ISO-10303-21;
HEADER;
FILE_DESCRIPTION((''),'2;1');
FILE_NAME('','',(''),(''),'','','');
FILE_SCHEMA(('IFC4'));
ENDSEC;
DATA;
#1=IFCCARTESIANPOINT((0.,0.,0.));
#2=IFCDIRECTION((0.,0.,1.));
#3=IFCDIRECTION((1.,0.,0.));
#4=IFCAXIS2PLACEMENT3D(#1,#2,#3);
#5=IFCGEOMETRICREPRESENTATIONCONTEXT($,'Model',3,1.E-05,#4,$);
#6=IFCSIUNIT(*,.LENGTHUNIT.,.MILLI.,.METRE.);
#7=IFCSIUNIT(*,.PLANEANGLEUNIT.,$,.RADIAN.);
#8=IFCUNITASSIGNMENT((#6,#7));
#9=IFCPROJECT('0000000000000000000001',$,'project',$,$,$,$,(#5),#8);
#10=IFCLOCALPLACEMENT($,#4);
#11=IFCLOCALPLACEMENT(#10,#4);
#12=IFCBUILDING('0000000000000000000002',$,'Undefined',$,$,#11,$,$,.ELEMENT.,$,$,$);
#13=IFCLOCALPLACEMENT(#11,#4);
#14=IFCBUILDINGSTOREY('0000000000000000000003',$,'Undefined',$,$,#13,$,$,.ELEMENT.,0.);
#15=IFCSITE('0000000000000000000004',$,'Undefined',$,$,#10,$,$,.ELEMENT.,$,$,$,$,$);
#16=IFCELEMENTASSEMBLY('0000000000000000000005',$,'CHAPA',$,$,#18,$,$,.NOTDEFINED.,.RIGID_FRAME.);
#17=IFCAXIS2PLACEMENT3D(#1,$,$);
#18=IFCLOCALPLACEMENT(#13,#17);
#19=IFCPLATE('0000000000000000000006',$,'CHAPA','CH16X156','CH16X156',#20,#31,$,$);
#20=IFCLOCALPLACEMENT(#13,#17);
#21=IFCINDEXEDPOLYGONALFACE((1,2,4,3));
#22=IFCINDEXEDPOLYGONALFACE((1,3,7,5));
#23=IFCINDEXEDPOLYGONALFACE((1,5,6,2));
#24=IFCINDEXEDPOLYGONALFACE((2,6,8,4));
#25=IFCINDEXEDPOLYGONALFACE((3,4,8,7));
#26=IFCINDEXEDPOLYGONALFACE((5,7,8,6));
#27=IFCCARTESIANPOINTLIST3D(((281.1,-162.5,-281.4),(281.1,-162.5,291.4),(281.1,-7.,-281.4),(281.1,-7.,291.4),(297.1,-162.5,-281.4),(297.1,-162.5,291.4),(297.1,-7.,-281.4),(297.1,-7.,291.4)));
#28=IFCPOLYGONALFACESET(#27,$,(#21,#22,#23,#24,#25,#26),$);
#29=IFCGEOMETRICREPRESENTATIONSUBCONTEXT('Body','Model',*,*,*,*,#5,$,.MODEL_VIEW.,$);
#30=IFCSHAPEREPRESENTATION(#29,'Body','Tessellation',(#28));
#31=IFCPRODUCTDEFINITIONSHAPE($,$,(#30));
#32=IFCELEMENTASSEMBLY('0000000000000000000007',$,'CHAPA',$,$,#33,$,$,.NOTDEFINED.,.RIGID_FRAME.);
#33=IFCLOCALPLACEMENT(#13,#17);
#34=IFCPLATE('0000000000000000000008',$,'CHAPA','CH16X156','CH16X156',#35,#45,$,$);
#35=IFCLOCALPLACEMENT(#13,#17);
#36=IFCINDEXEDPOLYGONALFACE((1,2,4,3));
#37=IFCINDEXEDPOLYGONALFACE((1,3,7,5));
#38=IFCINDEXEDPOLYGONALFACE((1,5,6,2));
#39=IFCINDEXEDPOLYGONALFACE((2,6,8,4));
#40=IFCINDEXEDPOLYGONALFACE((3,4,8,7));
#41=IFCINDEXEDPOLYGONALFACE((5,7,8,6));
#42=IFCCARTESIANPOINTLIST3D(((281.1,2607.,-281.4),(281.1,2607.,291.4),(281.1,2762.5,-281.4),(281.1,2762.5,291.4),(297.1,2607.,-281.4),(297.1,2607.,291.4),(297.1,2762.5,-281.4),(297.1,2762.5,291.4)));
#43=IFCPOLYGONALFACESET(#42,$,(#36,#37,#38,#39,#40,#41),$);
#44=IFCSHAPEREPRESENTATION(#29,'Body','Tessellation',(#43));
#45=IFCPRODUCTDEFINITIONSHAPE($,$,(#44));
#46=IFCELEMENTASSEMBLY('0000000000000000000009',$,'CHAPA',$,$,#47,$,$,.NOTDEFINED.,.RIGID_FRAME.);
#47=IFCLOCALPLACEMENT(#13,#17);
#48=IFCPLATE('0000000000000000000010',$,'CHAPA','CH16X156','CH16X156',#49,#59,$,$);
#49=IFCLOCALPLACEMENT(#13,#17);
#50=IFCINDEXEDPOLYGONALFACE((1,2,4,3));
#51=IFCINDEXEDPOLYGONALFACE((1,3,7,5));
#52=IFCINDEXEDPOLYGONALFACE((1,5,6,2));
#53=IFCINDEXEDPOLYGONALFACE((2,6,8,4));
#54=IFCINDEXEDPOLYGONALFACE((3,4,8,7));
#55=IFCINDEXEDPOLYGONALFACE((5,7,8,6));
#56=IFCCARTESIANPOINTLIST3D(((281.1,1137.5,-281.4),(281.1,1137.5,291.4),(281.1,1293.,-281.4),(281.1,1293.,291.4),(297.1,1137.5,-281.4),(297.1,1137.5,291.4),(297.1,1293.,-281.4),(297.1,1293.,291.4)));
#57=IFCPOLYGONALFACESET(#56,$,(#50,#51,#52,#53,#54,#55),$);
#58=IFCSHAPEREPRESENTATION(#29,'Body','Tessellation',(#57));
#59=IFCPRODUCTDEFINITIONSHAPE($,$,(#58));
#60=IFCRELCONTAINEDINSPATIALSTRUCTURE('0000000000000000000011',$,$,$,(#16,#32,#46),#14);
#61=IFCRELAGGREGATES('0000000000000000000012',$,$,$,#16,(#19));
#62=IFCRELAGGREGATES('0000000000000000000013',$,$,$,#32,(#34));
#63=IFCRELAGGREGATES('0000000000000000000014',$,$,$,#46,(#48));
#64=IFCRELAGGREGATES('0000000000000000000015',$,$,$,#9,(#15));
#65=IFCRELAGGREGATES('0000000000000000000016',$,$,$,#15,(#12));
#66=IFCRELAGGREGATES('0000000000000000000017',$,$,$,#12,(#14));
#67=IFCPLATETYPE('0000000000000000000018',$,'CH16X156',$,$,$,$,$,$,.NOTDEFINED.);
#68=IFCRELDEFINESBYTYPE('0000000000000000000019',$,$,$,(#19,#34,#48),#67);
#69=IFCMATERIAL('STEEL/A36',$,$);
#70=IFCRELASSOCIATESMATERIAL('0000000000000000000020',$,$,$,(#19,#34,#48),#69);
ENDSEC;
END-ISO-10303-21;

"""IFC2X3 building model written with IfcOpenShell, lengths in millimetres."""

from ifc_helpers import new_model, si_unit, frame, origin_with_axes, place, context, subcontext, project, spatial, polyline, outline, extrude, material, type_object, element, aggregate, save


model = new_model("IFC2X3")

# Units and contexts
model_context = context("Model", 3, precision=1e-05, world=origin_with_axes())
body_context = subcontext(model_context, "Body", "Model", "MODEL_VIEW")
ifc_project = project(units=[si_unit("LENGTHUNIT", "METRE", prefix="MILLI"), si_unit("PLANEANGLEUNIT", "RADIAN")], contexts=[model_context])

# Site, building, storey
site_placement = place(None, origin_with_axes())
site = spatial("IfcSite", under=ifc_project, at=site_placement, Name="Undefined", CompositionType="ELEMENT")
building_placement = place(site_placement, origin_with_axes())
building = spatial("IfcBuilding", under=site, at=building_placement, Name="Undefined", CompositionType="ELEMENT")
storey_placement = place(building_placement, origin_with_axes())
storey = spatial("IfcBuildingStorey", under=building, at=storey_placement, Name="Undefined", CompositionType="ELEMENT", Elevation=0.0)

# Element assemblies, plates
ifc_material_1 = material(Name="STEEL/A36")
plate_type = type_object("IfcPlateType", Name="CH16X156", PredefinedType="NOTDEFINED")
assembly_1_placement = place(storey_placement, origin_with_axes())
assembly_1 = element("IfcElementAssembly", 1, at=assembly_1_placement, inside=storey, Name="CHAPA", AssemblyPlace="NOTDEFINED", PredefinedType="RIGID_FRAME")
plate_1_placement = place(assembly_1_placement, frame((289.1, -7.0, 291.4), z_axis=(1.0, 0.0, 0.0), x_axis=(0.0, -1.0, 0.0)))
plate_1 = element("IfcPlate", 2, at=plate_1_placement, type_object=plate_type, material=ifc_material_1, Name="CHAPA", Description="CH16X156", ObjectType="CH16X156", context=body_context, shape_type="SweptSolid", body=[
    extrude(outline(polyline([(0.0, 0.0), (155.5, 0.0), (155.5, 572.8), (0.0, 572.8), (0.0, 0.0)])), frame((0.0, 0.0, -8.0), z_axis=(0.0, 0.0, 1.0), x_axis=(1.0, 0.0, 0.0)), (0.0, 0.0, 1.0), 16.0),
])
aggregate(assembly_1, [plate_1])
assembly_2_placement = place(storey_placement, origin_with_axes())
assembly_2 = element("IfcElementAssembly", 3, at=assembly_2_placement, inside=storey, Name="CHAPA", AssemblyPlace="NOTDEFINED", PredefinedType="RIGID_FRAME")
plate_2_placement = place(assembly_2_placement, frame((289.1, 2762.5, 291.4), z_axis=(1.0, 0.0, 0.0), x_axis=(0.0, -1.0, 0.0)))
plate_2 = element("IfcPlate", 4, at=plate_2_placement, type_object=plate_type, material=ifc_material_1, Name="CHAPA", Description="CH16X156", ObjectType="CH16X156", context=body_context, shape_type="SweptSolid", body=[
    extrude(outline(polyline([(0.0, 0.0), (155.5, 0.0), (155.5, 572.8), (0.0, 572.8), (0.0, 0.0)])), frame((0.0, 0.0, -8.0), z_axis=(0.0, 0.0, 1.0), x_axis=(1.0, 0.0, 0.0)), (0.0, 0.0, 1.0), 16.0),
])
aggregate(assembly_2, [plate_2])
assembly_3_placement = place(storey_placement, origin_with_axes())
assembly_3 = element("IfcElementAssembly", 5, at=assembly_3_placement, inside=storey, Name="CHAPA", AssemblyPlace="NOTDEFINED", PredefinedType="RIGID_FRAME")
plate_3_placement = place(assembly_3_placement, frame((289.1, 1293.0, 291.4), z_axis=(1.0, 0.0, 0.0), x_axis=(0.0, -1.0, 0.0)))
plate_3 = element("IfcPlate", 6, at=plate_3_placement, type_object=plate_type, material=ifc_material_1, Name="CHAPA", Description="CH16X156", ObjectType="CH16X156", context=body_context, shape_type="SweptSolid", body=[
    extrude(outline(polyline([(0.0, 0.0), (155.5, 0.0), (155.5, 572.8), (0.0, 572.8), (0.0, 0.0)])), frame((0.0, 0.0, -8.0), z_axis=(0.0, 0.0, 1.0), x_axis=(1.0, 0.0, 0.0)), (0.0, 0.0, 1.0), 16.0),
])
aggregate(assembly_3, [plate_3])

save(model, "model.ifc")
